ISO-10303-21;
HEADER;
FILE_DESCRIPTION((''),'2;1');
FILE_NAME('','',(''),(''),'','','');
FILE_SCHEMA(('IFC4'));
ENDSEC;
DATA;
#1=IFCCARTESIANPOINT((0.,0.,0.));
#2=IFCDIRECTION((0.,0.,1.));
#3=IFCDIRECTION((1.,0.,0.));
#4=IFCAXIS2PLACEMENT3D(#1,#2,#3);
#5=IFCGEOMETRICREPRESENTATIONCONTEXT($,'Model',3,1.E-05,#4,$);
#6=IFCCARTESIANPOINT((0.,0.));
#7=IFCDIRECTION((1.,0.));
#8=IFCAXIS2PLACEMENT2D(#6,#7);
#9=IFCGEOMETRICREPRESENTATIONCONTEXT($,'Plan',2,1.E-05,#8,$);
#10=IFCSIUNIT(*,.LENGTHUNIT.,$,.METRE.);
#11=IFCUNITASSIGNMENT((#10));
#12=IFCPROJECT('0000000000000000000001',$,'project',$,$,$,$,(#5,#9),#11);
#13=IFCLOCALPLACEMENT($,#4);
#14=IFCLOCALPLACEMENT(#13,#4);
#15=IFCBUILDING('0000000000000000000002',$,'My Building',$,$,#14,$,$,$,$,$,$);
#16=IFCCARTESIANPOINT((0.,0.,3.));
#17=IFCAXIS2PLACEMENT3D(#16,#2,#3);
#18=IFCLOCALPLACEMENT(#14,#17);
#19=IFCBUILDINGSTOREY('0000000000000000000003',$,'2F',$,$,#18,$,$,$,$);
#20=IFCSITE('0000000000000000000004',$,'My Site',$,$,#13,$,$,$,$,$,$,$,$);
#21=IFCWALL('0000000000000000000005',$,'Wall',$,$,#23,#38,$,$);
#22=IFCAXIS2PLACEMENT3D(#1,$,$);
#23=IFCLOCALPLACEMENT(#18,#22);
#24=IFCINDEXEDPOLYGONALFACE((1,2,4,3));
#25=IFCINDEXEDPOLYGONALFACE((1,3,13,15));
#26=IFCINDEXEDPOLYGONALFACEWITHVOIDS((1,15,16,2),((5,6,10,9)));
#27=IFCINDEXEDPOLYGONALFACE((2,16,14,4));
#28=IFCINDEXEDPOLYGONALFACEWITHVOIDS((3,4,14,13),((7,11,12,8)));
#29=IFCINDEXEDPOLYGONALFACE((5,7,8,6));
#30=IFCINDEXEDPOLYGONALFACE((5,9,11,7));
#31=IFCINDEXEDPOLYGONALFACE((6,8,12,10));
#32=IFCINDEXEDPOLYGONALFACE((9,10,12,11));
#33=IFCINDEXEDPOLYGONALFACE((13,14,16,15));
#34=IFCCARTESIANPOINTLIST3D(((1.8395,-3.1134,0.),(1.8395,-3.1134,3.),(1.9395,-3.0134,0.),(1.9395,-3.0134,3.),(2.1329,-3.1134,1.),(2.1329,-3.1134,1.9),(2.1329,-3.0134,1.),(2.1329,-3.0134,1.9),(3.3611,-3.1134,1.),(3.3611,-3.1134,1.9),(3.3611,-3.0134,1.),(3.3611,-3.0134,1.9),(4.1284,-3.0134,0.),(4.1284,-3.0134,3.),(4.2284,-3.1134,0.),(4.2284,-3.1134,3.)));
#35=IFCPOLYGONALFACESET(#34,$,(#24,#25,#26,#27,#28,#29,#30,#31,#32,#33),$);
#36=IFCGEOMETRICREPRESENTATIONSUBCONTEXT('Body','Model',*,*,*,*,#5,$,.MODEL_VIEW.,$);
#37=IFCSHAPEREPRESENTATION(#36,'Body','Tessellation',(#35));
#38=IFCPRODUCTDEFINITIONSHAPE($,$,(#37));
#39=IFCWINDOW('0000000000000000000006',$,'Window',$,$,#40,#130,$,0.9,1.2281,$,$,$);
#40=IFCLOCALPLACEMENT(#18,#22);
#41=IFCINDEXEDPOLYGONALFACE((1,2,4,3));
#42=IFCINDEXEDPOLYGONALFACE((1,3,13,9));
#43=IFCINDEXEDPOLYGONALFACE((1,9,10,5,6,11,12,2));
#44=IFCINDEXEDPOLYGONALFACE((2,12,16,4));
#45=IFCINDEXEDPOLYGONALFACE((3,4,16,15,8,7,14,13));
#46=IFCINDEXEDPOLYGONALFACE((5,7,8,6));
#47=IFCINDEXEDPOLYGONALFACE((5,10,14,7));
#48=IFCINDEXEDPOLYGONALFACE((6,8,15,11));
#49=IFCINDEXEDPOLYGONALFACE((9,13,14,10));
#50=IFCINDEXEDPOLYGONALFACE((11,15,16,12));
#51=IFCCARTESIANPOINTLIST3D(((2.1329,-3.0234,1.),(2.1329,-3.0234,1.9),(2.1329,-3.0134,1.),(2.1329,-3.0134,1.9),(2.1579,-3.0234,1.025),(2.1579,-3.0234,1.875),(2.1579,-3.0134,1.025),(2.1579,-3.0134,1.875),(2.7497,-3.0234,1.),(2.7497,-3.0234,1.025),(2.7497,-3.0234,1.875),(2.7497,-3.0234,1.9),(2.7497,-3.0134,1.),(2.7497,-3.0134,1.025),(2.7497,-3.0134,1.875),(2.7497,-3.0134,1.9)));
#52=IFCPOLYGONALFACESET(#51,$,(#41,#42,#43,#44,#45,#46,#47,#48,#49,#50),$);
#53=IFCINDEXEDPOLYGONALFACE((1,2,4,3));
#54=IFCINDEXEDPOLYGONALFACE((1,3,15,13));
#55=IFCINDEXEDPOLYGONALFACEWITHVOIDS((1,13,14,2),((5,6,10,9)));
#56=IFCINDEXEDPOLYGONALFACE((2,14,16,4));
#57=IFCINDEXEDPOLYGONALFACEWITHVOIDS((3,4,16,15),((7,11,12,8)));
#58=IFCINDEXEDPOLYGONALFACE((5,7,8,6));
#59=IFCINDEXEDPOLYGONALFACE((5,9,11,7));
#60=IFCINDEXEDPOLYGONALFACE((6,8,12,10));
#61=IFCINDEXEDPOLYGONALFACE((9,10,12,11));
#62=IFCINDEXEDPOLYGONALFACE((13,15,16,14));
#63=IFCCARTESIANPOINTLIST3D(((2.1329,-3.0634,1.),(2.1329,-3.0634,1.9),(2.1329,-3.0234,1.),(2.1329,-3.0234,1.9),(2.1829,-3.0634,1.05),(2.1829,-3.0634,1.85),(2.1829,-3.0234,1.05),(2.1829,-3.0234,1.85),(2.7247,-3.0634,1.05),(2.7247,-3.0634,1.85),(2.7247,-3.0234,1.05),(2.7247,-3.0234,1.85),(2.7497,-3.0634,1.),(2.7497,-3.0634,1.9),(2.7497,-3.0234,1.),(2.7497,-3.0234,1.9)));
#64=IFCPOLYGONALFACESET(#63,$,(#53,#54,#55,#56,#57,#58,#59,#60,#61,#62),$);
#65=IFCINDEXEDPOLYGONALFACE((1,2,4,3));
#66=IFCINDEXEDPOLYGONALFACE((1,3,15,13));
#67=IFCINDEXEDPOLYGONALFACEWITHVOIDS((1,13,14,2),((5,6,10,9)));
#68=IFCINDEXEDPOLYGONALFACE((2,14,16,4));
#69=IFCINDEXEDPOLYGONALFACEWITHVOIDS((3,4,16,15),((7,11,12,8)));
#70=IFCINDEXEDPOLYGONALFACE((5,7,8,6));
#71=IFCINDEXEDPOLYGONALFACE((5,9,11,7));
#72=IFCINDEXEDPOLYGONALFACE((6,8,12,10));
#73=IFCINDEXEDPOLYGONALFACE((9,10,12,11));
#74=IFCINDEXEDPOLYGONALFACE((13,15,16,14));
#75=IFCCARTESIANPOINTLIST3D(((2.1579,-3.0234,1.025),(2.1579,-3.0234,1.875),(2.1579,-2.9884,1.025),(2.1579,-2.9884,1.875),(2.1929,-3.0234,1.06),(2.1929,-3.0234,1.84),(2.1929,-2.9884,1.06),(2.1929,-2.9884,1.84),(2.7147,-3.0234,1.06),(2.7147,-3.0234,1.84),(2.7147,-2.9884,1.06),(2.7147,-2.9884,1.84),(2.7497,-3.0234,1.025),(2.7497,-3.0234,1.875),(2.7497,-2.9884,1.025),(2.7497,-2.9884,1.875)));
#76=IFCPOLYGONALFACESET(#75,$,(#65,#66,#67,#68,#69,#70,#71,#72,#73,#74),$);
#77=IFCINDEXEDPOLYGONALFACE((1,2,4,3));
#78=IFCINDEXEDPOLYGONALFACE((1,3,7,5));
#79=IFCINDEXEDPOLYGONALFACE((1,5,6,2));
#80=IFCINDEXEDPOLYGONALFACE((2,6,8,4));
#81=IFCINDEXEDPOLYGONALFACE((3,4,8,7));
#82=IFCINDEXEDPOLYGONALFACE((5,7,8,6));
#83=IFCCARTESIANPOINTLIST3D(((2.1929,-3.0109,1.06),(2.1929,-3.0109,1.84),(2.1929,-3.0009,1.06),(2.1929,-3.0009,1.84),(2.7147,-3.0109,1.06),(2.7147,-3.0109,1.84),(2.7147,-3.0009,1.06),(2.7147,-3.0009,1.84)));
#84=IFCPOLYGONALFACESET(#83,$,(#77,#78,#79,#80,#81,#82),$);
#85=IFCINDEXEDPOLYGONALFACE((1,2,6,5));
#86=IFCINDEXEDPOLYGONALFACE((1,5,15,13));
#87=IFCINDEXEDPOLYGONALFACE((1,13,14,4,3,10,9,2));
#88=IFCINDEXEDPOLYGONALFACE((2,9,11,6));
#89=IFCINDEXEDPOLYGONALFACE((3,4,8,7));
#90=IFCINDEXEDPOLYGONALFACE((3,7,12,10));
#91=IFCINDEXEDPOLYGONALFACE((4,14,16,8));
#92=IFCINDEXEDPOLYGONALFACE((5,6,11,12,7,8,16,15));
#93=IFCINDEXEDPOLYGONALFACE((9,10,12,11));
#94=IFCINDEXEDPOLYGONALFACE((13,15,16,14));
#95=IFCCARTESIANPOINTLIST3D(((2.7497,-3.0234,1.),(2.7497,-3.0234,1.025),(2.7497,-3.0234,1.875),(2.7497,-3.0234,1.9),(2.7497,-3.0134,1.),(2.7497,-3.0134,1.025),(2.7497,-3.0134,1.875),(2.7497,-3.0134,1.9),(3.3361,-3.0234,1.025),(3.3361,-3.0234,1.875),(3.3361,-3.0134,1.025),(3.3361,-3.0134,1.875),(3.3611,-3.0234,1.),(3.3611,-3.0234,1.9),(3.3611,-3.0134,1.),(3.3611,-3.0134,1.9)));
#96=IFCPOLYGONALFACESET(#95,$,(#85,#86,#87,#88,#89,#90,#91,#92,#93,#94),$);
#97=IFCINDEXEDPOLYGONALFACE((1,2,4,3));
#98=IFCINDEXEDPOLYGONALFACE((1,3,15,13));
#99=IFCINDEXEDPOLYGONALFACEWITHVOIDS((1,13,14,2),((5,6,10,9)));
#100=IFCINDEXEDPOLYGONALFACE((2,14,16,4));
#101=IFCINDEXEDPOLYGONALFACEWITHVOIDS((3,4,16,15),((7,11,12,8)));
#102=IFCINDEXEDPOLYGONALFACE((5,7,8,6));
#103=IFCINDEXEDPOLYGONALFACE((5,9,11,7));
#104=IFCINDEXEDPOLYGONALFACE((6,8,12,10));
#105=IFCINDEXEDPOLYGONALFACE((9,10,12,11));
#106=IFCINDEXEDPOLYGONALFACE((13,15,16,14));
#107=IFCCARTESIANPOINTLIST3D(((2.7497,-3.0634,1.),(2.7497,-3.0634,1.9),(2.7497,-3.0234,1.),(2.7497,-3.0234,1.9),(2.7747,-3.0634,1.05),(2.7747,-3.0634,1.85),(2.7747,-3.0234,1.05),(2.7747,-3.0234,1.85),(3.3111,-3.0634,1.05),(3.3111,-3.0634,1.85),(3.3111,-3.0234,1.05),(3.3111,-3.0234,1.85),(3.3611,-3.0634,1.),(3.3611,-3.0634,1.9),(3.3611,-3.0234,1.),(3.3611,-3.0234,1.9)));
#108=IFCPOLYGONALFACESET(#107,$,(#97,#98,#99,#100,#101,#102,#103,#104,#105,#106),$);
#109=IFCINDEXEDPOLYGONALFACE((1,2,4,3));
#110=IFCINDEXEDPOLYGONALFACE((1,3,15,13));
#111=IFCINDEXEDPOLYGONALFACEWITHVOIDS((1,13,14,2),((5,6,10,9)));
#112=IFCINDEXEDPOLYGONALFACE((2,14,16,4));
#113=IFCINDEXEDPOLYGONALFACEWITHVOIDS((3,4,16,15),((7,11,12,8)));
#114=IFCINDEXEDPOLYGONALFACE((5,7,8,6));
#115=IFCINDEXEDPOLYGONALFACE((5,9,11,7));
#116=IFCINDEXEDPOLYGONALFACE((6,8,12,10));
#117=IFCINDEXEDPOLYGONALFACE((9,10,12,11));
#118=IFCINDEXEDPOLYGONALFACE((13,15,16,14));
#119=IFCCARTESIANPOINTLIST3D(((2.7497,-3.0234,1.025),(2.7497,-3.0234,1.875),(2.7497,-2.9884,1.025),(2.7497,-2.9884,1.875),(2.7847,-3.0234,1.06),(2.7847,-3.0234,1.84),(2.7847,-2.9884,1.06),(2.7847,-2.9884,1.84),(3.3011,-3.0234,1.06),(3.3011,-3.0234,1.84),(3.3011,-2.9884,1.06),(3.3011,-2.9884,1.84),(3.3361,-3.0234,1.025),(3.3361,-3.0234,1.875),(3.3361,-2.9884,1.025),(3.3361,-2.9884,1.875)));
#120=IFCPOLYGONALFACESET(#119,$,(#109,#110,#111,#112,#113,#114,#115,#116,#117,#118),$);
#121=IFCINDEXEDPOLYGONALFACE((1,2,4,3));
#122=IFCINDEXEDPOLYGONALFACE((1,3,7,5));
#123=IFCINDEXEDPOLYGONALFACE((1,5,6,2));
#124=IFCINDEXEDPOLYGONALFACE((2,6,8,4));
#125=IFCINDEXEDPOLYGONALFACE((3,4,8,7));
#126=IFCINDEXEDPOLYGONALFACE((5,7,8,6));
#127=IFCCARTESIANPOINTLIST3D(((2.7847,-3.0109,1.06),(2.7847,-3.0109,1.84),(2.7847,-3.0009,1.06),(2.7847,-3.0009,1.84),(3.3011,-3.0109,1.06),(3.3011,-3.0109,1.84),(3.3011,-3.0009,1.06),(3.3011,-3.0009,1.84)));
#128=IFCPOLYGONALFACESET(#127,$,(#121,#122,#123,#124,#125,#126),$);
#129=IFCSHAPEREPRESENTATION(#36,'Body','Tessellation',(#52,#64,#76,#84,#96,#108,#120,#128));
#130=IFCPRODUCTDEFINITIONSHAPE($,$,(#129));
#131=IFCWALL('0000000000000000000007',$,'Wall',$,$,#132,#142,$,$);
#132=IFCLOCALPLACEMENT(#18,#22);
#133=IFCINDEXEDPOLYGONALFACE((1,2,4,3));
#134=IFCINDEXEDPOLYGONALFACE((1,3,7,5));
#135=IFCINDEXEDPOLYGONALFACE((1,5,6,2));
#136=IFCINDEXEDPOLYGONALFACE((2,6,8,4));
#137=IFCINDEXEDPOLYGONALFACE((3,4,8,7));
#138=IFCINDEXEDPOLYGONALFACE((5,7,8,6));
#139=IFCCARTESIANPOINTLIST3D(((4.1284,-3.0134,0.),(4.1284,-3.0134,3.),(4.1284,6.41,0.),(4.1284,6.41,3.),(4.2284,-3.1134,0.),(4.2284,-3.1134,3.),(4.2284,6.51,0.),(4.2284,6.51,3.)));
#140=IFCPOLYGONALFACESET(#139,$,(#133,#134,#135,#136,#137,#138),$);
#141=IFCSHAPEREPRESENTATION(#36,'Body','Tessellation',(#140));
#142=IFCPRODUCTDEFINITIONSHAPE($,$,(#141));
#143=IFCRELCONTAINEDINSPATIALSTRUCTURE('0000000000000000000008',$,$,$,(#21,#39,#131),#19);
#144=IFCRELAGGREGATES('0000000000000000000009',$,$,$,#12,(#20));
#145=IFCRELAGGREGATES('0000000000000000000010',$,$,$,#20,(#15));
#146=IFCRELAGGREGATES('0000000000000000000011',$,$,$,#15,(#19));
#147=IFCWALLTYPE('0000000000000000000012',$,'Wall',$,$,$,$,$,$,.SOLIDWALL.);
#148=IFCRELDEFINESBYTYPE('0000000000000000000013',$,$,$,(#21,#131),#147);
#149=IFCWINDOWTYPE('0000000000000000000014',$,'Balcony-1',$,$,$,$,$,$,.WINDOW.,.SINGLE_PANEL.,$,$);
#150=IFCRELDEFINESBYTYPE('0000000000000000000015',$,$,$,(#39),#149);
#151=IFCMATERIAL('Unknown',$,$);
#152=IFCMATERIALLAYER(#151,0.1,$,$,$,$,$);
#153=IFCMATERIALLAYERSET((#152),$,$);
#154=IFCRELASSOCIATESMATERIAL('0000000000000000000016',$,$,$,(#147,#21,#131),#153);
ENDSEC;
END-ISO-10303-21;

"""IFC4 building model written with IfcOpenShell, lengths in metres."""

from ifc_helpers import new_model, entity, si_unit, frame, origin_with_axes, origin_2d_with_axis, place, context, subcontext, project, spatial, line, indexed_curve, outline, extrude, shape, source, transform, mapped, material, layer, layer_set, layer_usage, type_object, type_shapes, element, fill, save


model = new_model("IFC4")

# Units and contexts
model_context = context("Model", 3, precision=1e-05, world=origin_with_axes())
plan_context = context("Plan", 2, precision=1e-05, world=origin_2d_with_axis())
body_context_1 = subcontext(model_context, "Body", "Model", "MODEL_VIEW")
body_context_2 = subcontext(plan_context, "Body", "Plan", "PLAN_VIEW")
ifc_project = project(units=[si_unit("LENGTHUNIT", "METRE")], contexts=[model_context, plan_context])

# Site, building, storey
site_placement = place(None, origin_with_axes())
site = spatial("IfcSite", under=ifc_project, at=site_placement, Name="My Site")
building_placement = place(site_placement, origin_with_axes())
building = spatial("IfcBuilding", under=site, at=building_placement, Name="My Building")
storey_placement = place(building_placement, frame((0.0, 0.0, 3.0), z_axis=(0.0, 0.0, 1.0), x_axis=(1.0, 0.0, 0.0)))
storey = spatial("IfcBuildingStorey", under=building, at=storey_placement, Name="2F")

# Shared definitions
ifc_material = material(Name="Unknown")

# Shared definitions
ifc_layer_1 = layer(ifc_material, 0.1)
ifc_layer_set_1 = layer_set([ifc_layer_1])
wall_type = type_object("IfcWallType", Name="Wall", PredefinedType="SOLIDWALL", material=ifc_layer_set_1)

# Wall, opening, window
ifc_layer_usage_1 = layer_usage(ifc_layer_set_1, "AXIS2", "POSITIVE", 0.0)
wall_1_placement = place(storey_placement, frame((1.8395, -3.1134, 0.0), z_axis=(0.0, 0.0, 1.0), x_axis=(1.0, 0.0, 0.0)))
wall_1 = element("IfcWall", 1, at=wall_1_placement, inside=storey, type_object=wall_type, material=ifc_layer_usage_1, Name="Wall", context=body_context_1, shape_type="SweptSolid", body=[
    extrude(outline(indexed_curve([(0.0, 0.0), (0.1, 0.1), (2.2889, 0.1), (2.3889, 0.0)], segments=[line(1, 2, 3, 4, 1)])), origin_with_axes(), (0.0, 0.0, 1.0), 3.0),
])
shared_shape_1 = source(origin_with_axes(), body_context_1, "Body", "SweptSolid", [
    extrude(outline(indexed_curve([(0.0, 0.0), (1.2281, 0.0), (1.2281, 0.9), (0.0, 0.9)], segments=[line(1, 2, 3, 4, 1)])), frame((0.0, -0.6, 0.0), z_axis=(0.0, -1.0, 0.0), x_axis=(1.0, 0.0, 0.0)), (0.0, 0.0, -1.0), 1.2),
])
opening_1_placement = place(wall_1_placement, frame((0.2934, 0.0, 1.0), z_axis=(0.0, 0.0, 1.0), x_axis=(1.0, 0.0, 0.0)))
opening_1 = element("IfcOpeningElement", 2, at=opening_1_placement, cuts=wall_1, PredefinedType="OPENING", context=body_context_1, shape_type="MappedRepresentation", body=[
    mapped(shared_shape_1, transform((0.0, 0.0, 0.0), x_axis=(1.0, 0.0, 0.0), y_axis=(0.0, 1.0, 0.0), z_axis=(0.0, 0.0, 1.0), scale=1.0)),
])
window_type_1 = type_object("IfcWindowType", Name="Balcony-1", PartitioningType="SINGLE_PANEL", PredefinedType="WINDOW")
shared_shape_2 = source(origin_with_axes(), body_context_1, "Body", "SweptSolid", [
    extrude(outline(indexed_curve([(0.6167, 0.0), (0.0, 0.0), (0.0, 0.9), (0.6167, 0.9), (0.6167, 0.875), (0.025, 0.875), (0.025, 0.025), (0.6167, 0.025)], segments=[line(1, 2, 3, 4, 5, 6, 7, 8, 1)])), frame((0.0, 0.09, 0.0), z_axis=(0.0, -1.0, 0.0), x_axis=(1.0, 0.0, 0.0)), (0.0, 0.0, -1.0), 0.01),
    extrude(outline(indexed_curve([(0.0, 0.0), (0.6167, 0.0), (0.6167, 0.9), (0.0, 0.9)], segments=[line(1, 2, 3, 4, 1)]), holes=[indexed_curve([(0.05, 0.05), (0.5917, 0.05), (0.5917, 0.85), (0.05, 0.85)], segments=[line(1, 2, 3, 4, 1)])]), frame((0.0, 0.05, 0.0), z_axis=(0.0, -1.0, 0.0), x_axis=(1.0, 0.0, 0.0)), (0.0, 0.0, -1.0), 0.04),
    extrude(outline(indexed_curve([(0.0, 0.0), (0.5917, 0.0), (0.5917, 0.85), (0.0, 0.85)], segments=[line(1, 2, 3, 4, 1)]), holes=[indexed_curve([(0.035, 0.035), (0.5567, 0.035), (0.5567, 0.815), (0.035, 0.815)], segments=[line(1, 2, 3, 4, 1)])]), frame((0.025, 0.09, 0.025), z_axis=(0.0, -1.0, 0.0), x_axis=(1.0, 0.0, 0.0)), (0.0, 0.0, -1.0), 0.035),
    extrude(outline(indexed_curve([(0.035, 0.035), (0.5567, 0.035), (0.5567, 0.815), (0.035, 0.815)], segments=[line(1, 2, 3, 4, 1)])), frame((0.025, 0.1025, 0.025), z_axis=(0.0, -1.0, 0.0), x_axis=(1.0, 0.0, 0.0)), (0.0, 0.0, -1.0), 0.01),
    extrude(outline(indexed_curve([(0.0, 0.9), (0.6114, 0.9), (0.6114, 0.0), (0.0, 0.0), (0.0, 0.025), (0.5864, 0.025), (0.5864, 0.875), (0.0, 0.875)], segments=[line(1, 2, 3, 4, 5, 6, 7, 8, 1)])), frame((0.6167, 0.09, 0.0), z_axis=(0.0, -1.0, 0.0), x_axis=(1.0, 0.0, 0.0)), (0.0, 0.0, -1.0), 0.01),
    extrude(outline(indexed_curve([(0.0, 0.0), (0.6114, 0.0), (0.6114, 0.9), (0.0, 0.9)], segments=[line(1, 2, 3, 4, 1)]), holes=[indexed_curve([(0.025, 0.05), (0.5614, 0.05), (0.5614, 0.85), (0.025, 0.85)], segments=[line(1, 2, 3, 4, 1)])]), frame((0.6167, 0.05, 0.0), z_axis=(0.0, -1.0, 0.0), x_axis=(1.0, 0.0, 0.0)), (0.0, 0.0, -1.0), 0.04),
    extrude(outline(indexed_curve([(0.0, 0.0), (0.5864, 0.0), (0.5864, 0.85), (0.0, 0.85)], segments=[line(1, 2, 3, 4, 1)]), holes=[indexed_curve([(0.035, 0.035), (0.5514, 0.035), (0.5514, 0.815), (0.035, 0.815)], segments=[line(1, 2, 3, 4, 1)])]), frame((0.6167, 0.09, 0.025), z_axis=(0.0, -1.0, 0.0), x_axis=(1.0, 0.0, 0.0)), (0.0, 0.0, -1.0), 0.035),
    extrude(outline(indexed_curve([(0.035, 0.035), (0.5514, 0.035), (0.5514, 0.815), (0.035, 0.815)], segments=[line(1, 2, 3, 4, 1)])), frame((0.6167, 0.1025, 0.025), z_axis=(0.0, -1.0, 0.0), x_axis=(1.0, 0.0, 0.0)), (0.0, 0.0, -1.0), 0.01),
])
shared_shape_3 = source(origin_with_axes(), body_context_2, "Body", "Curve2D", [
    entity("IfcIndexedPolyCurve", entity("IfcCartesianPointList2D", [[0.05, 0.05], [0.5917, 0.05]])),
    entity("IfcIndexedPolyCurve", entity("IfcCartesianPointList2D", [[0.0, 0.1], [0.025, 0.1], [0.025, 0.09], [0.05, 0.09], [0.05, 0.05], [0.0, 0.05]]), [entity("IfcLineIndex", [1, 2, 3, 4, 5, 6, 1])]),
    entity("IfcIndexedPolyCurve", entity("IfcCartesianPointList2D", [[0.6167, 0.1], [0.6167, 0.1], [0.6167, 0.09], [0.5917, 0.09], [0.5917, 0.05], [0.6167, 0.05]])),
    entity("IfcIndexedPolyCurve", entity("IfcCartesianPointList2D", [[0.025, 0.09], [0.06, 0.09], [0.06, 0.125], [0.025, 0.125]]), [entity("IfcLineIndex", [1, 2, 3, 4, 1])]),
    entity("IfcIndexedPolyCurve", entity("IfcCartesianPointList2D", [[0.6167, 0.09], [0.5817, 0.09], [0.5817, 0.125], [0.6167, 0.125]]), [entity("IfcLineIndex", [1, 2, 3, 4, 1])]),
    entity("IfcIndexedPolyCurve", entity("IfcCartesianPointList2D", [[0.06, 0.09], [0.5817, 0.09]])),
    entity("IfcIndexedPolyCurve", entity("IfcCartesianPointList2D", [[0.06, 0.125], [0.5817, 0.125]])),
    entity("IfcIndexedPolyCurve", entity("IfcCartesianPointList2D", [[0.06, 0.1075], [0.5817, 0.1075]])),
    entity("IfcIndexedPolyCurve", entity("IfcCartesianPointList2D", [[0.6417, 0.05], [1.1781, 0.05]])),
    entity("IfcIndexedPolyCurve", entity("IfcCartesianPointList2D", [[0.6167, 0.1], [0.6167, 0.1], [0.6167, 0.09], [0.6417, 0.09], [0.6417, 0.05], [0.6167, 0.05]])),
    entity("IfcIndexedPolyCurve", entity("IfcCartesianPointList2D", [[1.2281, 0.1], [1.2031, 0.1], [1.2031, 0.09], [1.1781, 0.09], [1.1781, 0.05], [1.2281, 0.05]]), [entity("IfcLineIndex", [1, 2, 3, 4, 5, 6, 1])]),
    entity("IfcIndexedPolyCurve", entity("IfcCartesianPointList2D", [[0.6167, 0.09], [0.6517, 0.09], [0.6517, 0.125], [0.6167, 0.125]]), [entity("IfcLineIndex", [1, 2, 3, 4, 1])]),
    entity("IfcIndexedPolyCurve", entity("IfcCartesianPointList2D", [[1.2031, 0.09], [1.1681, 0.09], [1.1681, 0.125], [1.2031, 0.125]]), [entity("IfcLineIndex", [1, 2, 3, 4, 1])]),
    entity("IfcIndexedPolyCurve", entity("IfcCartesianPointList2D", [[0.6517, 0.09], [1.1681, 0.09]])),
    entity("IfcIndexedPolyCurve", entity("IfcCartesianPointList2D", [[0.6517, 0.125], [1.1681, 0.125]])),
    entity("IfcIndexedPolyCurve", entity("IfcCartesianPointList2D", [[0.6517, 0.1075], [1.1681, 0.1075]])),
])
type_shapes(window_type_1, [shared_shape_2, shared_shape_3])
window_1_placement = place(opening_1_placement, frame((0.0, 0.0, 0.0), z_axis=(0.0, 0.0, 1.0), x_axis=(1.0, 0.0, 0.0)))
window_1 = element("IfcWindow", 3, at=window_1_placement, inside=storey, type_object=window_type_1, Name="Window", OverallHeight=0.9, OverallWidth=1.2281, shapes=[
    shape(body_context_1, "Body", "MappedRepresentation", [mapped(shared_shape_2, transform((0.0, 0.0, 0.0), x_axis=(1.0, 0.0, 0.0), y_axis=(0.0, 1.0, 0.0), z_axis=(0.0, 0.0, 1.0), scale=1.0))]),
    shape(body_context_2, "Body", "MappedRepresentation", [mapped(shared_shape_3, transform((0.0, 0.0, 0.0), x_axis=(1.0, 0.0, 0.0), y_axis=(0.0, 1.0, 0.0), z_axis=(0.0, 0.0, 1.0), scale=1.0))]),
])
fill(opening_1, window_1)

# Wall
ifc_layer_usage_2 = layer_usage(ifc_layer_set_1, "AXIS2", "POSITIVE", 0.0)
wall_2_placement = place(storey_placement, frame((4.2284, -3.1134, 0.0), z_axis=(0.0, 0.0, 1.0), x_axis=(0.0, 1.0, 0.0)))
element("IfcWall", 4, at=wall_2_placement, inside=storey, type_object=wall_type, material=ifc_layer_usage_2, Name="Wall", context=body_context_1, shape_type="SweptSolid", body=[
    extrude(outline(indexed_curve([(0.0, 0.0), (0.1, 0.1), (9.5233, 0.1), (9.6233, 0.0)], segments=[line(1, 2, 3, 4, 1)])), origin_with_axes(), (0.0, 0.0, 1.0), 3.0),
])

save(model, "model.ifc")
